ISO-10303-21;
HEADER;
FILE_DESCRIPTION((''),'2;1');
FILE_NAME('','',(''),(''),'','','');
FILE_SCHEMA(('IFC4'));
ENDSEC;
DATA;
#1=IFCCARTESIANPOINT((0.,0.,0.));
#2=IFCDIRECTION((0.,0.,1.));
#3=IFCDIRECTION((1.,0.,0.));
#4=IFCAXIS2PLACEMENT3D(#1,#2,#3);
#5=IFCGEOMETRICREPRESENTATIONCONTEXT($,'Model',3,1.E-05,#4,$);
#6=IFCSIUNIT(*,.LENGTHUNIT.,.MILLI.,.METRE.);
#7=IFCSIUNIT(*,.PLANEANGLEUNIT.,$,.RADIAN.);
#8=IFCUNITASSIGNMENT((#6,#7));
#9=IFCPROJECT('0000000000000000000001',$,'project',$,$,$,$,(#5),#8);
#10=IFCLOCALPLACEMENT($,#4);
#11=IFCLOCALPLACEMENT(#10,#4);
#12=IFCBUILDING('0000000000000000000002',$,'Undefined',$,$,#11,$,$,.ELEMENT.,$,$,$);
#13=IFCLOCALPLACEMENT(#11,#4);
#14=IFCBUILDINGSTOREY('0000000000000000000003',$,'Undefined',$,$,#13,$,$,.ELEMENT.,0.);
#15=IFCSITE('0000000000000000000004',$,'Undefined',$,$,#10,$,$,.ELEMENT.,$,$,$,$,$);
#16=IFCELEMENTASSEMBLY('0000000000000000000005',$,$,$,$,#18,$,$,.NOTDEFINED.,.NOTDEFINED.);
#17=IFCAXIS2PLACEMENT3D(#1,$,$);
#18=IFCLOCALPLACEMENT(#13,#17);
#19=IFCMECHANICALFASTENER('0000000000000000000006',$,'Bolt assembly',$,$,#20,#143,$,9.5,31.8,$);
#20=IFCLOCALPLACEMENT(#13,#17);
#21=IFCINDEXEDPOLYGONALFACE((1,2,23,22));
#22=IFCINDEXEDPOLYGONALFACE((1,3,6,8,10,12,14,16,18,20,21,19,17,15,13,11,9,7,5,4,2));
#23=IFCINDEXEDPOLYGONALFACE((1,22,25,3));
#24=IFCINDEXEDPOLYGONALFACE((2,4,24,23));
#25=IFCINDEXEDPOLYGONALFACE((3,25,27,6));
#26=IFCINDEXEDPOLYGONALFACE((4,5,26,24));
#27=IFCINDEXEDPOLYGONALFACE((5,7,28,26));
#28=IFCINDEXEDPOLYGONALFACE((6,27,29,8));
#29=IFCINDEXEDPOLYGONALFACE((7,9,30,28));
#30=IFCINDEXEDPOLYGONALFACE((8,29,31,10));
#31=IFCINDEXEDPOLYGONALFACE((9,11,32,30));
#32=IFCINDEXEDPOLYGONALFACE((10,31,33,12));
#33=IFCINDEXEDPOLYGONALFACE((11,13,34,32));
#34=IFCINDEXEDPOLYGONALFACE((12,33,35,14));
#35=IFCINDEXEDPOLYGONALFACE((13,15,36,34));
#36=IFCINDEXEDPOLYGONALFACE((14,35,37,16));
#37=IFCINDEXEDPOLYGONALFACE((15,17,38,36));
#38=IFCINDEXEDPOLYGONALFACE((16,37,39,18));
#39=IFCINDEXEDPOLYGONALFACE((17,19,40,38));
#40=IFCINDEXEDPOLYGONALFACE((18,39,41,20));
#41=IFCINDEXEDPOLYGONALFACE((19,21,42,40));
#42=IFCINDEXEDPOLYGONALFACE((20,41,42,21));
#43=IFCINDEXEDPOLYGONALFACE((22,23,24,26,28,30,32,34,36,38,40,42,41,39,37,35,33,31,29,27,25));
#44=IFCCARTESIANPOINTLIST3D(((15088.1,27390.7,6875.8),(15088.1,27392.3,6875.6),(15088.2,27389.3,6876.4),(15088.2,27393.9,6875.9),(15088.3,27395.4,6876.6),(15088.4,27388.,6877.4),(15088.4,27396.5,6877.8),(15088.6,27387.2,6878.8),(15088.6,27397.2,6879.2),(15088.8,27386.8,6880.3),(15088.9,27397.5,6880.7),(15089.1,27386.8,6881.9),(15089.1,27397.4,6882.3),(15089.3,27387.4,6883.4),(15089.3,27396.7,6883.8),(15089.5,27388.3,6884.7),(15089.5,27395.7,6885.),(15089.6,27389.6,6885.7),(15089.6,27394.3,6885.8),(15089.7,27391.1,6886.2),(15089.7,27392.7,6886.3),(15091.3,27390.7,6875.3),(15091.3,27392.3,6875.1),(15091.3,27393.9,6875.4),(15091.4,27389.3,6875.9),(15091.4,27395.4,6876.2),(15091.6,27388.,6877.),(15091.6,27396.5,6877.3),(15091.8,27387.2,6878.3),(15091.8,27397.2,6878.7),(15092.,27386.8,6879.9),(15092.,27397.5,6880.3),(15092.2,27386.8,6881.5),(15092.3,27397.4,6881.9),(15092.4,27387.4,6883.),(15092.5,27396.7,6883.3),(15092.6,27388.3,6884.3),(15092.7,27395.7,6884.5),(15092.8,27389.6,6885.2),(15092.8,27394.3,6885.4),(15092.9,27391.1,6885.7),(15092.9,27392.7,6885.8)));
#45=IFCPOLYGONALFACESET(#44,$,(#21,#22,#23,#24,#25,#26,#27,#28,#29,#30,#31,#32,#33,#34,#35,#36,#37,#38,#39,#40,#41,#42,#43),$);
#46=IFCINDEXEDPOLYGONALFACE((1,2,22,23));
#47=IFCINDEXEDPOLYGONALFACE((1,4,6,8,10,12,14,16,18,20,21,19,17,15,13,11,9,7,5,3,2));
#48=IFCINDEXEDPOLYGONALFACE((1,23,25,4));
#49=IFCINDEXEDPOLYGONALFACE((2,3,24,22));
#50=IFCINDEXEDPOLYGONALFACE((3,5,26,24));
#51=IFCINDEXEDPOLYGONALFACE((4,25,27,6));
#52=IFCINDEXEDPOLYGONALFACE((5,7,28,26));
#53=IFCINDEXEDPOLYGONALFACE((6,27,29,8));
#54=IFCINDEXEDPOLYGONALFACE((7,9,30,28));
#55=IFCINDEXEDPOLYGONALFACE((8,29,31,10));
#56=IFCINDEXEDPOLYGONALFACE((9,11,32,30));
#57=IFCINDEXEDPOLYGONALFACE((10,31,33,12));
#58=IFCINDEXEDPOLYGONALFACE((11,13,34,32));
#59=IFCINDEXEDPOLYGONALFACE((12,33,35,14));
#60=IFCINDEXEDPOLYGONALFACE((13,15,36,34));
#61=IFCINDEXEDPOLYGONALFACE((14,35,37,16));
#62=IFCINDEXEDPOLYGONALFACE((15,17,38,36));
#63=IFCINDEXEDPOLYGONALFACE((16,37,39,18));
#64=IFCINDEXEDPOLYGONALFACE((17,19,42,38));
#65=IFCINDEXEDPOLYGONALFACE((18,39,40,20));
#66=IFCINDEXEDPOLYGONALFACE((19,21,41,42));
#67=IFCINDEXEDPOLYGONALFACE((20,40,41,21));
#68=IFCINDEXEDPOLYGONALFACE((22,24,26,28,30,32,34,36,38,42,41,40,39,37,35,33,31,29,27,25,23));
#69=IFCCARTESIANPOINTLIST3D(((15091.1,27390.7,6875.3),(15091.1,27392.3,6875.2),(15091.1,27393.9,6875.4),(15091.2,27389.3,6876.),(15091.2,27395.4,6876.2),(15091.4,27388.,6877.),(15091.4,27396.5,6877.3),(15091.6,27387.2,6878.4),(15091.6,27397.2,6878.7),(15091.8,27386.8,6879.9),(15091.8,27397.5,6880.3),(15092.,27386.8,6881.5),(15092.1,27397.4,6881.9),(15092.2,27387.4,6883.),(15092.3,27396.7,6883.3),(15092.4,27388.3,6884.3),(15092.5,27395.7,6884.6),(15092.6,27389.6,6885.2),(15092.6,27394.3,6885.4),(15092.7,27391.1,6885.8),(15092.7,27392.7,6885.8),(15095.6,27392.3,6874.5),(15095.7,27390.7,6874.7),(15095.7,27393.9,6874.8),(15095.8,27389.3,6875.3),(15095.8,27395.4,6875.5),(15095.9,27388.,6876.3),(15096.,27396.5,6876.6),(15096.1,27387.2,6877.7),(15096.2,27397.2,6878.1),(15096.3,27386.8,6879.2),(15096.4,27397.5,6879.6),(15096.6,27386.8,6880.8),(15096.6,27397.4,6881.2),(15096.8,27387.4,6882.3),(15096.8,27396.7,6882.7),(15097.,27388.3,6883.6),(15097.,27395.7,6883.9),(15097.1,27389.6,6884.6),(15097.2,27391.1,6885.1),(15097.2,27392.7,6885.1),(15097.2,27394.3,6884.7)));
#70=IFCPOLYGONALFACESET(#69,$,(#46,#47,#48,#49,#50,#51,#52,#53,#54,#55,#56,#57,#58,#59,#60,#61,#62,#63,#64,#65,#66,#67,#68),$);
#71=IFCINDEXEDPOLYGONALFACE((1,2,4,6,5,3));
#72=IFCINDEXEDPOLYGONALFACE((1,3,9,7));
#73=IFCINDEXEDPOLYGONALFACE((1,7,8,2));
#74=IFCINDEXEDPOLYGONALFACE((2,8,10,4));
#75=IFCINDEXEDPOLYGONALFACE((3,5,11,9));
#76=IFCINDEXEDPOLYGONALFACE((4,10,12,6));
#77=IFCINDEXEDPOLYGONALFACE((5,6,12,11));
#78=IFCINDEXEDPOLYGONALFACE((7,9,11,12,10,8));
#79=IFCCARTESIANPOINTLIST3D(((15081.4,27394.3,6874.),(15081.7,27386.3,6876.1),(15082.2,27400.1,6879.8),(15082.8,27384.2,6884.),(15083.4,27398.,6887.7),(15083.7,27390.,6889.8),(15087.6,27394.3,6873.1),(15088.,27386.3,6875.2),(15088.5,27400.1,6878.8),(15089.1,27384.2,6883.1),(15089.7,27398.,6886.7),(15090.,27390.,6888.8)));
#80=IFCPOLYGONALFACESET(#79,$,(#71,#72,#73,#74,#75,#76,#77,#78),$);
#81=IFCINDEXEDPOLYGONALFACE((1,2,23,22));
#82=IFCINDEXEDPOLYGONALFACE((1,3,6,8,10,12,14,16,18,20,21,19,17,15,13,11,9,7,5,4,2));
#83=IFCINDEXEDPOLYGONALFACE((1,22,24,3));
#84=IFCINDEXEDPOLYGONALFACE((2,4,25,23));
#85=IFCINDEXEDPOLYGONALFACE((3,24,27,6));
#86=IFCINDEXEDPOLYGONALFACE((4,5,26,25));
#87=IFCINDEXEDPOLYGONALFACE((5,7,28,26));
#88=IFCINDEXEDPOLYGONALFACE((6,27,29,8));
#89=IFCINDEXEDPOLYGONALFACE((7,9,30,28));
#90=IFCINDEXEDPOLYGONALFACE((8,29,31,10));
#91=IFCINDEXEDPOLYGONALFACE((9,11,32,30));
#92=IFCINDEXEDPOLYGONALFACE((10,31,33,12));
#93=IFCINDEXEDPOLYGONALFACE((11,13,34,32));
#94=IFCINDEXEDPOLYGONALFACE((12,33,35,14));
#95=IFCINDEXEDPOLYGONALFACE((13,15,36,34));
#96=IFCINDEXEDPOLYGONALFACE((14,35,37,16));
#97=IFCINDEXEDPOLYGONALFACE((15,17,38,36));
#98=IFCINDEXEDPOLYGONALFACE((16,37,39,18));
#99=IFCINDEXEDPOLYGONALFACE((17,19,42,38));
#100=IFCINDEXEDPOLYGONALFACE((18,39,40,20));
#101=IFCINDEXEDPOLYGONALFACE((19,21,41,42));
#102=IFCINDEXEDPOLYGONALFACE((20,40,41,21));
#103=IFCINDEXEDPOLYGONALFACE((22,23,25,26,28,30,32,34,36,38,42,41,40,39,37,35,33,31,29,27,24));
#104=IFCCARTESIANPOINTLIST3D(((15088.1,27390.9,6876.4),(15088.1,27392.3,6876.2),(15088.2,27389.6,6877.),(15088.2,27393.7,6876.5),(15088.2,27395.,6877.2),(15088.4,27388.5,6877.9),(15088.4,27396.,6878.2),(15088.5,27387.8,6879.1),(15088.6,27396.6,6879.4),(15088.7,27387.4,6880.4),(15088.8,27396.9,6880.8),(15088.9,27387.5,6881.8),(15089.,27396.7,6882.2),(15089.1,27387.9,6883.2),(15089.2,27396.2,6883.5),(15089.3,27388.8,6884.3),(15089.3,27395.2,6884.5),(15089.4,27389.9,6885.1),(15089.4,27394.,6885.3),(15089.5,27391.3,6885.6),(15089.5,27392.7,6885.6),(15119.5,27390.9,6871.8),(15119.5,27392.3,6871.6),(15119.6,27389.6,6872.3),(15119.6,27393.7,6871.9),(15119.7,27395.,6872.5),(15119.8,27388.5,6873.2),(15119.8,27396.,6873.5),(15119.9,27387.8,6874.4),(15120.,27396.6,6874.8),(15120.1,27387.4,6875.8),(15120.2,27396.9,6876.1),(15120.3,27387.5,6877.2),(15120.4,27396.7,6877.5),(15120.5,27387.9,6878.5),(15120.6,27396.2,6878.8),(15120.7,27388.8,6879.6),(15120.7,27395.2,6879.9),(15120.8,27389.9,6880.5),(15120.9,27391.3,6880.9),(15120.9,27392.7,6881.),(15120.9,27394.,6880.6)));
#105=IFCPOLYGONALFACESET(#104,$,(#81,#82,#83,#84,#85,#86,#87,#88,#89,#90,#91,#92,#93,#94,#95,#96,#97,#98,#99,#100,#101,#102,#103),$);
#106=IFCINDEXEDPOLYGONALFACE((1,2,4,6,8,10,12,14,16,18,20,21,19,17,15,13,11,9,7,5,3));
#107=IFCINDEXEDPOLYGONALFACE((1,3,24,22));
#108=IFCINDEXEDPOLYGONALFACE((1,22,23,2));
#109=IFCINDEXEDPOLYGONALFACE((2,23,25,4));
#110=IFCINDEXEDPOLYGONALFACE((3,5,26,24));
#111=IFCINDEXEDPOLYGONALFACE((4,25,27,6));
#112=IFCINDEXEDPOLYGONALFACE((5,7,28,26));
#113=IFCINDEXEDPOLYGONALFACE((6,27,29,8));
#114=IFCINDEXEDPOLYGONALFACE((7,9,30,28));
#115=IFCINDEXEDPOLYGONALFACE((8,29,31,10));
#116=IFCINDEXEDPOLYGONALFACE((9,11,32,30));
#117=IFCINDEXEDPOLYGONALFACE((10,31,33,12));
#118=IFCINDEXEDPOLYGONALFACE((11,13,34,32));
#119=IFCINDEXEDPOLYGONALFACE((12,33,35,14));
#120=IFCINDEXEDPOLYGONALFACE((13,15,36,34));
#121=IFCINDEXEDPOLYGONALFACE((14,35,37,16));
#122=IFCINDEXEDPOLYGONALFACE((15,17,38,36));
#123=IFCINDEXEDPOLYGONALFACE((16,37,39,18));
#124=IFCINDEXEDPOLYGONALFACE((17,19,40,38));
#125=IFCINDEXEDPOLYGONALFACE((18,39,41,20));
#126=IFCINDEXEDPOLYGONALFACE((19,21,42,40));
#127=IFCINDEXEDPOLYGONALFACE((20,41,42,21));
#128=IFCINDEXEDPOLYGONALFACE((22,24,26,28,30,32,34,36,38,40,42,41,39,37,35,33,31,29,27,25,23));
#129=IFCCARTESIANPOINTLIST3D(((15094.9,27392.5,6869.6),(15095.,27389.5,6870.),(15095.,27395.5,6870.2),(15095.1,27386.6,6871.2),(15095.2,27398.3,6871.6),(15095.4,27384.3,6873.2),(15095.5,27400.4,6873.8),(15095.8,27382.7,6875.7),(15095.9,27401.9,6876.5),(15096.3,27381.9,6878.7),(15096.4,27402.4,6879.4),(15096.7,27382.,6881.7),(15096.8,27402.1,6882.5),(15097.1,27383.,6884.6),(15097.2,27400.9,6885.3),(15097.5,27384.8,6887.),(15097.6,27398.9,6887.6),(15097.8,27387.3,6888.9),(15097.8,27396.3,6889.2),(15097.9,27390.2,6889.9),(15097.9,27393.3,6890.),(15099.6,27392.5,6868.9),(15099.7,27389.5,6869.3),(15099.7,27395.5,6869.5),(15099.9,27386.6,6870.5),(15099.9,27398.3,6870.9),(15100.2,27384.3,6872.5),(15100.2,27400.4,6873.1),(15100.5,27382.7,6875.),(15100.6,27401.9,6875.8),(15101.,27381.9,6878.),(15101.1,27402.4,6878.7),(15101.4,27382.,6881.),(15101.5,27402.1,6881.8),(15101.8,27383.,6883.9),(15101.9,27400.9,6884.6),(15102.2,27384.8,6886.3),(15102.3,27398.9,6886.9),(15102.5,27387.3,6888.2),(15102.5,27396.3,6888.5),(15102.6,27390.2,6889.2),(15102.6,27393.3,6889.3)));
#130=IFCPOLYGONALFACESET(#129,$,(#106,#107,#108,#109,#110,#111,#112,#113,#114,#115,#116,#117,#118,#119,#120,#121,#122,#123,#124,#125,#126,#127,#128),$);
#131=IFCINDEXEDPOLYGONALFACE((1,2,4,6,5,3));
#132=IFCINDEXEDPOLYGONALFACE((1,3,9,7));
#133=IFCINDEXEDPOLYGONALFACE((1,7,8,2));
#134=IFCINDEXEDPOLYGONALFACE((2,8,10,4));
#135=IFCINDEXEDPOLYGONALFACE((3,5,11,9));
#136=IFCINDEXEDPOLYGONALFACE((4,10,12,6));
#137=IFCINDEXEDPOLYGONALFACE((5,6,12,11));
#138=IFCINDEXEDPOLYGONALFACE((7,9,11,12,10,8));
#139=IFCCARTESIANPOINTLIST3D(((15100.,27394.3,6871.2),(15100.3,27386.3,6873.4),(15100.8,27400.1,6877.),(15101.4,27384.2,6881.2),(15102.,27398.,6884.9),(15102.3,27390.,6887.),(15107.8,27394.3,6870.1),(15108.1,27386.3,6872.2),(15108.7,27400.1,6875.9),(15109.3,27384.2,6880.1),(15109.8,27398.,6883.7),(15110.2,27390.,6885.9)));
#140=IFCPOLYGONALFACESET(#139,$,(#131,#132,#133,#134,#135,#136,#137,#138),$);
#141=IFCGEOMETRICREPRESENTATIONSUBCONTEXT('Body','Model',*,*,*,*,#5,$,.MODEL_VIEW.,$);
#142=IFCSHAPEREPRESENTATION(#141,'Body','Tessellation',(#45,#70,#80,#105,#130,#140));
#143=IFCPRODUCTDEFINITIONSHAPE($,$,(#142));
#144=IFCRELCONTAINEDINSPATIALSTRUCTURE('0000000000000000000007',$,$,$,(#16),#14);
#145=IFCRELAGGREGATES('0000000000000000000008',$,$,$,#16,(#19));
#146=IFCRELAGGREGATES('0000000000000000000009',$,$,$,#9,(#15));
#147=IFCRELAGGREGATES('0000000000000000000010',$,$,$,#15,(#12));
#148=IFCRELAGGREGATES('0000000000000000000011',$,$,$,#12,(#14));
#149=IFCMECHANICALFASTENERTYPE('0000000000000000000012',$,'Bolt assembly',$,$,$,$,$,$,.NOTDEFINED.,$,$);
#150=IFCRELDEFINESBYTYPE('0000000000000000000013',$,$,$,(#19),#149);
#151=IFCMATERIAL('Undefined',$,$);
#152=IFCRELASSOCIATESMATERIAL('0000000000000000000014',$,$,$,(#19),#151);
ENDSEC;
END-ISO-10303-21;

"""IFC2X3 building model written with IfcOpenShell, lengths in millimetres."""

from ifc_helpers import new_model, si_unit, frame, origin_with_axes, origin_2d_with_axis, place, context, subcontext, project, spatial, polyline, circle, outline, extrude, source, transform, mapped, material, type_object, element, aggregate, save


model = new_model("IFC2X3")

# Units and contexts
model_context = context("Model", 3, precision=1e-05, world=origin_with_axes())
body_context = subcontext(model_context, "Body", "Model", "MODEL_VIEW")
ifc_project = project(units=[si_unit("LENGTHUNIT", "METRE", prefix="MILLI"), si_unit("PLANEANGLEUNIT", "RADIAN")], contexts=[model_context])

# Site, building, storey
site_placement = place(None, origin_with_axes())
site = spatial("IfcSite", under=ifc_project, at=site_placement, Name="Undefined", CompositionType="ELEMENT")
building_placement = place(site_placement, origin_with_axes())
building = spatial("IfcBuilding", under=site, at=building_placement, Name="Undefined", CompositionType="ELEMENT")
storey_placement = place(building_placement, origin_with_axes())
storey = spatial("IfcBuildingStorey", under=building, at=storey_placement, Name="Undefined", CompositionType="ELEMENT", Elevation=0.0)

# Element assembly
assembly_1_placement = place(storey_placement, origin_with_axes())
assembly_1 = element("IfcElementAssembly", 1, at=assembly_1_placement, inside=storey, AssemblyPlace="NOTDEFINED", PredefinedType="NOTDEFINED")

# Shared definitions
ifc_material_1 = material(Name="Undefined")
mechanical_fastener_type = type_object("IfcMechanicalFastenerType", Name="Bolt assembly")

# Mechanical fastener
shared_shape_1 = source(origin_with_axes(), body_context, "Body", "SweptSolid", [
    extrude(circle(Radius=5.4, at=origin_2d_with_axis()), frame((0.0, -3.1, 0.0), z_axis=(0.0, 1.0, 0.0), x_axis=(1.0, 0.0, 0.0)), (0.0, 0.0, 1.0), 3.2),
    extrude(circle(Radius=5.4, at=origin_2d_with_axis()), frame((0.0, -0.1, 0.0), z_axis=(0.0, 1.0, 0.0), x_axis=(1.0, 0.0, 0.0)), (0.0, 0.0, 1.0), 4.6),
    extrude(outline(polyline([(7.1, -4.1), (7.1, 4.1), (0.0, 8.2), (-7.1, 4.1), (-7.1, -4.1), (0.0, -8.2), (7.1, -4.1)])), frame((0.0, -9.6, 0.0), z_axis=(0.0, 1.0, 0.0), x_axis=(1.0, 0.0, 0.0)), (0.0, 0.0, 1.0), 6.3),
    extrude(circle(Radius=4.8, at=origin_2d_with_axis()), frame((0.0, -3.2, 0.0), z_axis=(0.0, 1.0, 0.0), x_axis=(1.0, 0.0, 0.0)), (0.0, 0.0, 1.0), 31.8),
    extrude(circle(Radius=10.3, at=origin_2d_with_axis()), frame((0.0, 4.5, 0.0), z_axis=(0.0, 1.0, 0.0), x_axis=(1.0, 0.0, 0.0)), (0.0, 0.0, 1.0), 4.8),
    extrude(outline(polyline([(7.1, -4.1), (7.1, 4.1), (0.0, 8.2), (-7.1, 4.1), (-7.1, -4.1), (0.0, -8.2), (7.1, -4.1)])), frame((0.0, 9.3, 0.0), z_axis=(0.0, 1.0, 0.0), x_axis=(1.0, 0.0, 0.0)), (0.0, 0.0, 1.0), 7.9),
])
mechanical_fastener_1_placement = place(assembly_1_placement, frame((15092.0, 27392.1, 6880.5), z_axis=(0.10338, 0.707107, 0.699509), x_axis=(0.10338, -0.707107, 0.699509)))
mechanical_fastener_1 = element("IfcMechanicalFastener", 2, at=mechanical_fastener_1_placement, type_object=mechanical_fastener_type, material=ifc_material_1, Name="Bolt assembly", NominalDiameter=9.5, NominalLength=31.8, context=body_context, shape_type="MappedRepresentation", body=[
    mapped(shared_shape_1, transform((0.0, 0.0, 0.0))),
])
aggregate(assembly_1, [mechanical_fastener_1])

save(model, "model.ifc")
